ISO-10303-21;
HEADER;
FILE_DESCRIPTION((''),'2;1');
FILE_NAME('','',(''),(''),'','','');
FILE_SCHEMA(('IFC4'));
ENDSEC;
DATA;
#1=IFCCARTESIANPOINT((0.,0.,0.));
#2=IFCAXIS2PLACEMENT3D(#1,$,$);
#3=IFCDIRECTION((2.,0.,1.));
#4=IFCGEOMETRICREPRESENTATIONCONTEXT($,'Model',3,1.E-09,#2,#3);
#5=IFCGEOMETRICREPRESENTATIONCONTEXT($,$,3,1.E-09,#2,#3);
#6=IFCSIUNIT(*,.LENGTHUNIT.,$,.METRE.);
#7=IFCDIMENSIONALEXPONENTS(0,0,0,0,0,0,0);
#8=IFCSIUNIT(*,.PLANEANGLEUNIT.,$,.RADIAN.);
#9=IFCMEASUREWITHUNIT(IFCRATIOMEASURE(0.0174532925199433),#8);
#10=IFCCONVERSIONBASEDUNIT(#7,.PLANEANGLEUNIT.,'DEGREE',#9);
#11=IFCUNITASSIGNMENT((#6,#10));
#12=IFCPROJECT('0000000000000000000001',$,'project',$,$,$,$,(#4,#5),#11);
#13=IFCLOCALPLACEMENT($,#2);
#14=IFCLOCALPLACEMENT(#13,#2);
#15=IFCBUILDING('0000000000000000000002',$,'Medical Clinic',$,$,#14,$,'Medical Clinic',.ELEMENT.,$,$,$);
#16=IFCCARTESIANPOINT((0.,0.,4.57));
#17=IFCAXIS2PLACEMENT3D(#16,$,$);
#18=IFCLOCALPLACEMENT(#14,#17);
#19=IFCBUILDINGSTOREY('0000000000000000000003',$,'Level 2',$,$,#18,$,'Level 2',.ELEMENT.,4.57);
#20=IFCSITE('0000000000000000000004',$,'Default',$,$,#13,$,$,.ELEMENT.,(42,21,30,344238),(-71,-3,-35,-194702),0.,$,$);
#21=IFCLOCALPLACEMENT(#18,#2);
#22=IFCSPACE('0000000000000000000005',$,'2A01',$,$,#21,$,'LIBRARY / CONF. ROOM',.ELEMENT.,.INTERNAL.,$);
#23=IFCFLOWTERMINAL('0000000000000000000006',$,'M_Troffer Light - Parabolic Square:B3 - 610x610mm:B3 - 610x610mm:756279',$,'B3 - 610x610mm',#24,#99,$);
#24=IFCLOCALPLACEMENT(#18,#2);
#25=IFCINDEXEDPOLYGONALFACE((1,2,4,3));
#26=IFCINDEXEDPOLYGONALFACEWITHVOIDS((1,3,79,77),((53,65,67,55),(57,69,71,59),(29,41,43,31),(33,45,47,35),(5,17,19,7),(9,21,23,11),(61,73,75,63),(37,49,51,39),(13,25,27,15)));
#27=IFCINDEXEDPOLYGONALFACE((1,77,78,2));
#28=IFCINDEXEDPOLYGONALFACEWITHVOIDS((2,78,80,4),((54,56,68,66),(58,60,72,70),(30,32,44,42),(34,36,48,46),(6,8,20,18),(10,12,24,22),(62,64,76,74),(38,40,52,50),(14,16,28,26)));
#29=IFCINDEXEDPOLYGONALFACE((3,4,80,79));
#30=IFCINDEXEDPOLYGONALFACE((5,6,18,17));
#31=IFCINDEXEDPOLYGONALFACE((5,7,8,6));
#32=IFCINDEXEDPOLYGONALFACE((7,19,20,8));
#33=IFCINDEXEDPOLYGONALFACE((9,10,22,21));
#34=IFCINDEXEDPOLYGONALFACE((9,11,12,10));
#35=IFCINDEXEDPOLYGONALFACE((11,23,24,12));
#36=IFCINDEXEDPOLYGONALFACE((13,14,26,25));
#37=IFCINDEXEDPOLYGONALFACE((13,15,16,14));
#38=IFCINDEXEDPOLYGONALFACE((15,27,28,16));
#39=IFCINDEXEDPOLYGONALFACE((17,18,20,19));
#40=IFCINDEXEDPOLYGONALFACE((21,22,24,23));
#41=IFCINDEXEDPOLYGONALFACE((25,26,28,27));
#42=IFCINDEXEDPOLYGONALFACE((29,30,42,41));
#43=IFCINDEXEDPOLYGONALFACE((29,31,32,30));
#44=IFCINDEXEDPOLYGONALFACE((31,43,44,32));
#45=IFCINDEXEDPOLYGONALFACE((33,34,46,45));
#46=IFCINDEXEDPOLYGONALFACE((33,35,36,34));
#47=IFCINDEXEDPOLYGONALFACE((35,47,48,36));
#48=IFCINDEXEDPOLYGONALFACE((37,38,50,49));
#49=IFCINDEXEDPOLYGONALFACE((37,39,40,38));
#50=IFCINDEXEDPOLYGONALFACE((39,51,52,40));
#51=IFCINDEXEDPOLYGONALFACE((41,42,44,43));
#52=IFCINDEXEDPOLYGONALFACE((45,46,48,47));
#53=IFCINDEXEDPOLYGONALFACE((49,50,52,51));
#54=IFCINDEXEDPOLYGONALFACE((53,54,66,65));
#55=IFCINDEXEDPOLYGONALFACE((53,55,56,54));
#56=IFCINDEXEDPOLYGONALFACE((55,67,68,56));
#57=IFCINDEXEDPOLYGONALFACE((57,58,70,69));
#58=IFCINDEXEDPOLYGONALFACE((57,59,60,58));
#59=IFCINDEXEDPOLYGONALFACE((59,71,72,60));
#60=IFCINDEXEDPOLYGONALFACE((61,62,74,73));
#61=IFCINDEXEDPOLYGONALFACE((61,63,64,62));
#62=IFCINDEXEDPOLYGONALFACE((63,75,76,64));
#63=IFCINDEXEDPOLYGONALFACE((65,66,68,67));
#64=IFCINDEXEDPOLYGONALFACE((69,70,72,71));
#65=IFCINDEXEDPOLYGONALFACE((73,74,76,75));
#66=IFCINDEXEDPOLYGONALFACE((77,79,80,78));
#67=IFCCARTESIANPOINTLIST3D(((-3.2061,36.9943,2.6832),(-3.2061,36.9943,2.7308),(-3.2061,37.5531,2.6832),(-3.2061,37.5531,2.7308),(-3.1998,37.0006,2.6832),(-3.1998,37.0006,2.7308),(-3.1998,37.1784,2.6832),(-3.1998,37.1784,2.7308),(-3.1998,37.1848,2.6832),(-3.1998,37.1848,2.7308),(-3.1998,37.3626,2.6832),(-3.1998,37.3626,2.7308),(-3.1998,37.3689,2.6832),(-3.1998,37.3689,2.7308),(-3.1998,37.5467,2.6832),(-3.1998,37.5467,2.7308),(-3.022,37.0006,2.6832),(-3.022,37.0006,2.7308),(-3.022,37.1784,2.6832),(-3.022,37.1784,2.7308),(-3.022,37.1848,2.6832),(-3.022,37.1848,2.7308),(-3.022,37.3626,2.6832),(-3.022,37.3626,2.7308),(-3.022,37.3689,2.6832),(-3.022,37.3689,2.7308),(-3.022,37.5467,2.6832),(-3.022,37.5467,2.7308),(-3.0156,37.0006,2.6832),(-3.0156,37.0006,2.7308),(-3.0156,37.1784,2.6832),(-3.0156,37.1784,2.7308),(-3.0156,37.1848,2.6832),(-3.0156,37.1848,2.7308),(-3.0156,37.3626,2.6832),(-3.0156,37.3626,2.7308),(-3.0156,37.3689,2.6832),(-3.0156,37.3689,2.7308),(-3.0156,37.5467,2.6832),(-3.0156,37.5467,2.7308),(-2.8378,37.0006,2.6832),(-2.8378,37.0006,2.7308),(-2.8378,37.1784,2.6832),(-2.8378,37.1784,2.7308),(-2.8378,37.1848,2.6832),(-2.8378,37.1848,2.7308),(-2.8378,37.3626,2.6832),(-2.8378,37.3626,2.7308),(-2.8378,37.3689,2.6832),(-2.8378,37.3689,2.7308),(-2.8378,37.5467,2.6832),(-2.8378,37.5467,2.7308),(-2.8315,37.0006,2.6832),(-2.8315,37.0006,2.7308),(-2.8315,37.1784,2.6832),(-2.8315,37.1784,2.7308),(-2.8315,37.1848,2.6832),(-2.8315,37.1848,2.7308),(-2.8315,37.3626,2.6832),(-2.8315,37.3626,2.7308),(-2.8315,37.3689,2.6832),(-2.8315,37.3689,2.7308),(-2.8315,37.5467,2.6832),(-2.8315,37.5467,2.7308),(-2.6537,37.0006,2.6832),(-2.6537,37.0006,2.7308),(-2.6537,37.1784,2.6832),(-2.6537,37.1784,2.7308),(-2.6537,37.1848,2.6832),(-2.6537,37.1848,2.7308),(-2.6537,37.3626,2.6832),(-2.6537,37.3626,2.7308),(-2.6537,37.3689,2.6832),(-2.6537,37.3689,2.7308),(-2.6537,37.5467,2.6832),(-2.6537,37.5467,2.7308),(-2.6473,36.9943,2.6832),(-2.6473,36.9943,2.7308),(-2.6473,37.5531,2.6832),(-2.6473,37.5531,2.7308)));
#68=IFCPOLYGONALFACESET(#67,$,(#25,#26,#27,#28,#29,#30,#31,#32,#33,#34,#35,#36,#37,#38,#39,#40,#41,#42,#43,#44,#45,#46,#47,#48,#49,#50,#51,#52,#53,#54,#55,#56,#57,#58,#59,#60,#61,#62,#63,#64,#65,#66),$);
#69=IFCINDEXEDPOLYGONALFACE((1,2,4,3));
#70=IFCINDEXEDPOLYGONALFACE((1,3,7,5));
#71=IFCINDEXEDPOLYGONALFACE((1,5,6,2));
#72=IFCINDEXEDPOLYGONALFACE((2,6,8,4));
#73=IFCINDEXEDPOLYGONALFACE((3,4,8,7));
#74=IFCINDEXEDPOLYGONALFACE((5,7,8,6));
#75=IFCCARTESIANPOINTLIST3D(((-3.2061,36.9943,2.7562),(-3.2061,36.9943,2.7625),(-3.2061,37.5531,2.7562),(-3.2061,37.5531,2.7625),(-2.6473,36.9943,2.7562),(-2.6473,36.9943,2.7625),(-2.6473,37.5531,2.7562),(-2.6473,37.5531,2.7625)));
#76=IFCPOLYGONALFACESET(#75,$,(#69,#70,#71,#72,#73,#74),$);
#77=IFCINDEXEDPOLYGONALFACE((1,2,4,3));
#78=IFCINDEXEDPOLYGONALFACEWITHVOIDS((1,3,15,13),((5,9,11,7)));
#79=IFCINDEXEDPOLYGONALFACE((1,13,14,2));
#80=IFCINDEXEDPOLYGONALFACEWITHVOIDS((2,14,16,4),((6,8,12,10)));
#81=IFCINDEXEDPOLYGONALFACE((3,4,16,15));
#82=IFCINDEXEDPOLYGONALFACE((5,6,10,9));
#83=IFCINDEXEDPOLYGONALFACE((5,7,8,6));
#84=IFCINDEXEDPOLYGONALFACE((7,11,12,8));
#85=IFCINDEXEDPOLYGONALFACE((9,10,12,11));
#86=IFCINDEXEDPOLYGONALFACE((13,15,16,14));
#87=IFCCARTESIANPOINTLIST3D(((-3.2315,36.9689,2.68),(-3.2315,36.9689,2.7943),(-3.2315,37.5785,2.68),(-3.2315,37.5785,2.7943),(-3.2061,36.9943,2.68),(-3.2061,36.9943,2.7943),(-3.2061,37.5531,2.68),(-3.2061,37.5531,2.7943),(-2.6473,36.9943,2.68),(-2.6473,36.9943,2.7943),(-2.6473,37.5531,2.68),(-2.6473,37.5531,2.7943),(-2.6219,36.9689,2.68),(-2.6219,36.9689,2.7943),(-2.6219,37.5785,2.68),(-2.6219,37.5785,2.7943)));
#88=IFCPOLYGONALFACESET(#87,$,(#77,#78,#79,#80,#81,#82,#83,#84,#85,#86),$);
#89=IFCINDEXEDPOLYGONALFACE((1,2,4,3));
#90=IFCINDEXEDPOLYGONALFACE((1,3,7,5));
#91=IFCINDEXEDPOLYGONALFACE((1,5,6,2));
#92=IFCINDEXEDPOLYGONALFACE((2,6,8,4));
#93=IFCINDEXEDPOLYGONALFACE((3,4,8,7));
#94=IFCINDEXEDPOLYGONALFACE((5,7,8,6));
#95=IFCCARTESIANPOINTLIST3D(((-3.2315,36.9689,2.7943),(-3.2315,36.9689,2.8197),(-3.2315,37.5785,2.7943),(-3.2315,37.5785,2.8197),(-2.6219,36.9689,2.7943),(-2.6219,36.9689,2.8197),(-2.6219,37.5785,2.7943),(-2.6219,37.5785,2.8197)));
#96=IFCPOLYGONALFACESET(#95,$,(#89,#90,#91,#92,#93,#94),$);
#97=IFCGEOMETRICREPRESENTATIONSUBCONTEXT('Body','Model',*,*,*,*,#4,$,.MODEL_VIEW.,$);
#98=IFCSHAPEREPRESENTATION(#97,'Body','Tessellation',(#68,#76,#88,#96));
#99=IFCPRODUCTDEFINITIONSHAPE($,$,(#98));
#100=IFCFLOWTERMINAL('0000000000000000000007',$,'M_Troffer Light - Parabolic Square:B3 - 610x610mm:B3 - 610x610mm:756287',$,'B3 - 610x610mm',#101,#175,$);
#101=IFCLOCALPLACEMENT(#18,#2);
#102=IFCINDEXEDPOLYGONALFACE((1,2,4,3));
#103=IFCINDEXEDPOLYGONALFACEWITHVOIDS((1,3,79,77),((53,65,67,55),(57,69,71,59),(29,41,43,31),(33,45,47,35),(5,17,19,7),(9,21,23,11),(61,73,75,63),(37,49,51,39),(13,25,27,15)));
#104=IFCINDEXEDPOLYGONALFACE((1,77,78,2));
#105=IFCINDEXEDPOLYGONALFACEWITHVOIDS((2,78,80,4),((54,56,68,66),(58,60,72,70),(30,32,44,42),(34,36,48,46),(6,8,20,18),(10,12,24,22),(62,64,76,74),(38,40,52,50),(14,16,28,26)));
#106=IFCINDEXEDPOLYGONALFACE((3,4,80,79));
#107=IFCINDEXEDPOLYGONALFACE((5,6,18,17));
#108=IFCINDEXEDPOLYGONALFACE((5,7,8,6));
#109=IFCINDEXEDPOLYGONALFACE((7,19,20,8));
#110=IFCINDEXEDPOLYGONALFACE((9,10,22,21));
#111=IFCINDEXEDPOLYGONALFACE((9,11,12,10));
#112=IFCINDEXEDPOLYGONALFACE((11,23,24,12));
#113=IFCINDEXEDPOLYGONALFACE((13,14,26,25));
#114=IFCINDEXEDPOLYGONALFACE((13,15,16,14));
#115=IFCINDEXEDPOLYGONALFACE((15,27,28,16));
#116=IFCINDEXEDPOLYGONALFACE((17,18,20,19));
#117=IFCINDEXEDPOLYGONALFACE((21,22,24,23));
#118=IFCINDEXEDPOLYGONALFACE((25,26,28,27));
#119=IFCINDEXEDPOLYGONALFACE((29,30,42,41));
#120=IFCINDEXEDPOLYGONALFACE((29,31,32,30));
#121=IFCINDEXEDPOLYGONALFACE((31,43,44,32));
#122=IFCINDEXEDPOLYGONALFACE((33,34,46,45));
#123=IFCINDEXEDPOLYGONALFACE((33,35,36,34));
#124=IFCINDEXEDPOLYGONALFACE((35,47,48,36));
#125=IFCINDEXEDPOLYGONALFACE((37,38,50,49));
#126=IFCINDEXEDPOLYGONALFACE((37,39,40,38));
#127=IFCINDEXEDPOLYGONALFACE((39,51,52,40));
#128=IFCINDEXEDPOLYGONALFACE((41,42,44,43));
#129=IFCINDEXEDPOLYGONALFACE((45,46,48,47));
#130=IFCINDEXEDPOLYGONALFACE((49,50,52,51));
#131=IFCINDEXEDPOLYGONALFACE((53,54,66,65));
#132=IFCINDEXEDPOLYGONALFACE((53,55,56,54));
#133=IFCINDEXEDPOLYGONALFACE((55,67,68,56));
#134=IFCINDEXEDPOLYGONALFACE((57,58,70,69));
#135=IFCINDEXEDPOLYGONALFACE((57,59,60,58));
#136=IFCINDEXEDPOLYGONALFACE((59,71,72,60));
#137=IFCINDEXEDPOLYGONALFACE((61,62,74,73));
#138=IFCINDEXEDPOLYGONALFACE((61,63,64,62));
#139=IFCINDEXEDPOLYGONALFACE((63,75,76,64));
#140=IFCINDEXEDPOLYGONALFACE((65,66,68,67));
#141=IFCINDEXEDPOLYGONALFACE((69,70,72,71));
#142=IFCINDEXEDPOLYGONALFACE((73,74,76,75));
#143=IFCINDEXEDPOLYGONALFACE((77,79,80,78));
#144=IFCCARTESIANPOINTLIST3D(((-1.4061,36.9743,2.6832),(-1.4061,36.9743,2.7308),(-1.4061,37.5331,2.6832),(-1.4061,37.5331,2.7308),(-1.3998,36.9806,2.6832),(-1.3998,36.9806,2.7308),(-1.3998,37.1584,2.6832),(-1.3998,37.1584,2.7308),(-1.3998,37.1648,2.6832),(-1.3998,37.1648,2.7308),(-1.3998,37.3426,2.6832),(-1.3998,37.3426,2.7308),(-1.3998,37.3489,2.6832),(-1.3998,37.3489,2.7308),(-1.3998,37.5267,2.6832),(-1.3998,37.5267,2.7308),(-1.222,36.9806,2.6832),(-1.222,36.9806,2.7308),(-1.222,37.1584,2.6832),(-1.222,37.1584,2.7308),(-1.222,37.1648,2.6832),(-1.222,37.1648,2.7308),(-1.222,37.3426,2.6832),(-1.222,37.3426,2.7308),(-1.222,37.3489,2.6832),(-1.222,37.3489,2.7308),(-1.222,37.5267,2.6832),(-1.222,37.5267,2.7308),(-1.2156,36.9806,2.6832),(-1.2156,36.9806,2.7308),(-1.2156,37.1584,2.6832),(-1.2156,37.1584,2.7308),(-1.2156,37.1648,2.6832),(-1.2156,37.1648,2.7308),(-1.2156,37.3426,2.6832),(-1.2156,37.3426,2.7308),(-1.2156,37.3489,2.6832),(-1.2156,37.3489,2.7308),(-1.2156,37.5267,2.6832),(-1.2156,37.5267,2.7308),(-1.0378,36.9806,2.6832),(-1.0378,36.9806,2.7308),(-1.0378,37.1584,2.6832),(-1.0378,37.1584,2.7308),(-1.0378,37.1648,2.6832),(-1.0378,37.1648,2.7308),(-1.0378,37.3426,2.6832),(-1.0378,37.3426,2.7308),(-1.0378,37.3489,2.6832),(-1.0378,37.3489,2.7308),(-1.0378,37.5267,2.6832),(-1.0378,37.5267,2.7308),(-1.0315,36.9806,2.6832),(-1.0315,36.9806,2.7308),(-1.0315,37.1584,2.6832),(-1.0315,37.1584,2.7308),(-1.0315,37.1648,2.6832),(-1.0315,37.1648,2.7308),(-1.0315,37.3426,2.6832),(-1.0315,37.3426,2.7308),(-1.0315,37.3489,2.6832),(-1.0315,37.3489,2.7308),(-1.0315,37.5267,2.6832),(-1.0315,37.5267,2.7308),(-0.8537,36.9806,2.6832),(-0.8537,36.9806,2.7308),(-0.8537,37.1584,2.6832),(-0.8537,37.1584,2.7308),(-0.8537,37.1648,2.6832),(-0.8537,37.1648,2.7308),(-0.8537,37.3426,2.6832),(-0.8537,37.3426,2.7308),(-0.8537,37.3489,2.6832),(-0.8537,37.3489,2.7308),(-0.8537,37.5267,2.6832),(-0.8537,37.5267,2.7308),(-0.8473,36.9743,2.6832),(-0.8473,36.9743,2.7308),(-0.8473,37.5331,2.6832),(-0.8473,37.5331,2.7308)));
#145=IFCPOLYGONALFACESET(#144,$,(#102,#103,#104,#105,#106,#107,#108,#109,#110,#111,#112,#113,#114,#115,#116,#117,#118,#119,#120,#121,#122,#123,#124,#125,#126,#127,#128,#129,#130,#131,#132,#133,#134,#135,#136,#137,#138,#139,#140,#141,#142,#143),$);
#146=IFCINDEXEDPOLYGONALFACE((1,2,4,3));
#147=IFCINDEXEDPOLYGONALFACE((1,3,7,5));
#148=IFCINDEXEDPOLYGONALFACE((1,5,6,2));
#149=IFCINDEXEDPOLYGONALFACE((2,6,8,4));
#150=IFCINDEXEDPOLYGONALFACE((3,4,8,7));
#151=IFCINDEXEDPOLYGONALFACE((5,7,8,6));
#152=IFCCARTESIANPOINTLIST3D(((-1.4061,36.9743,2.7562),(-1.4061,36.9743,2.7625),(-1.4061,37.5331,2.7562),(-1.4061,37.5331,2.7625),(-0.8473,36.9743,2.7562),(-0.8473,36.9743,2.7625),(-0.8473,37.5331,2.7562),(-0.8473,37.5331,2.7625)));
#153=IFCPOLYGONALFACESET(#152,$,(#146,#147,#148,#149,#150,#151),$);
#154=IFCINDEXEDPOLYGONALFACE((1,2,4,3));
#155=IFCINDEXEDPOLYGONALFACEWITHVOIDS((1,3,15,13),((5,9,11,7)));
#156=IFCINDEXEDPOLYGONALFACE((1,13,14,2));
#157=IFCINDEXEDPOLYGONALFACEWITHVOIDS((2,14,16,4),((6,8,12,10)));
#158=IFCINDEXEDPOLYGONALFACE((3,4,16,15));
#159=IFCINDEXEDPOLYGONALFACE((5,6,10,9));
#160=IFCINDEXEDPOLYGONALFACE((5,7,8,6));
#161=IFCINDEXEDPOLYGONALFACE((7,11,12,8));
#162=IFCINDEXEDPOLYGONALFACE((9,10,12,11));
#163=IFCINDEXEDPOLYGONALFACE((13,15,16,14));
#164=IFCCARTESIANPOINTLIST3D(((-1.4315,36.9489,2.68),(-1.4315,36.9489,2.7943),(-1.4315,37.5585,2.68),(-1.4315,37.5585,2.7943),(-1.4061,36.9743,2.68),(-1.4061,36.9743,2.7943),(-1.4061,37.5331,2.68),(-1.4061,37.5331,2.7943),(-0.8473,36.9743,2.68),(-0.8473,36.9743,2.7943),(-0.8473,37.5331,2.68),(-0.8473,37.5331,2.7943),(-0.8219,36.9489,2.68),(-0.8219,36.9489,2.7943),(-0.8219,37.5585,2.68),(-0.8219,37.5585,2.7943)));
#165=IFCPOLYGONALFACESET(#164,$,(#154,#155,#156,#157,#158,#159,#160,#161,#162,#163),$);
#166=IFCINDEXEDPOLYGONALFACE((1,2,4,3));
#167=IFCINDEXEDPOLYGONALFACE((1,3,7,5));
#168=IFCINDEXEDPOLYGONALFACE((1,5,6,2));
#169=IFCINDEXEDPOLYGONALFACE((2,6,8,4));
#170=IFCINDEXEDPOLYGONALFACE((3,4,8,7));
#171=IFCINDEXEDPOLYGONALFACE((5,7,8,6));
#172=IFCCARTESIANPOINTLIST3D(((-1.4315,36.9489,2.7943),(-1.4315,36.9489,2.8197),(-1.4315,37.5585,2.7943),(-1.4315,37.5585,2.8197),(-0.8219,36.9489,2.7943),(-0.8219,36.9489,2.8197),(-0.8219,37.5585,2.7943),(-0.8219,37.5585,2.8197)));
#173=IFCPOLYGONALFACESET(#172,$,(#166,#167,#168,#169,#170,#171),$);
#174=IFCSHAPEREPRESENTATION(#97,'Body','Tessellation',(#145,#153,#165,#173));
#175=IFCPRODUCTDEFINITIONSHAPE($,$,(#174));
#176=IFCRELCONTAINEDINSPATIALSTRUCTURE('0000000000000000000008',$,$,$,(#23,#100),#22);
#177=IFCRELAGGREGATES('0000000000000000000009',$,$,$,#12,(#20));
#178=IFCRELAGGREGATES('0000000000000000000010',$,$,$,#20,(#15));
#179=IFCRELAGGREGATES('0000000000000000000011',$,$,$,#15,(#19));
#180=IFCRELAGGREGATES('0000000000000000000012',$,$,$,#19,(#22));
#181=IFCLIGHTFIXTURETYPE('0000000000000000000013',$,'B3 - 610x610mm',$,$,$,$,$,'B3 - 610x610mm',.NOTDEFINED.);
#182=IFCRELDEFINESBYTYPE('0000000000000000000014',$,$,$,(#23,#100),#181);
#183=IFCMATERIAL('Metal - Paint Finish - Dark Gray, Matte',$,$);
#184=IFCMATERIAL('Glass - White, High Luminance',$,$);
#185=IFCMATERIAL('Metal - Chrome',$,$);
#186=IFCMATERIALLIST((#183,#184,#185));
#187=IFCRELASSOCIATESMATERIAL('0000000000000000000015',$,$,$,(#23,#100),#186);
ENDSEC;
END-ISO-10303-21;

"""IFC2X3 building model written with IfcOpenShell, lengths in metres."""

from ifc_helpers import new_model, entity, si_unit, converted_unit, direction, frame, origin, origin_2d_with_axis, place, context, subcontext, project, spatial, polyline, rectangle, outline, extrude, source, transform, mapped, material, material_list, type_object, type_shapes, element, save


model = new_model("IFC2X3")

# Units and contexts
model_context = context("Model", 3, precision=1e-09, world=origin(), true_north=direction((2.0, 0.0, 1.0)))
context_of_model = context(None, 3, precision=1e-09, world=origin(), true_north=direction((2.0, 0.0, 1.0)))
body_context = subcontext(model_context, "Body", "Model", "MODEL_VIEW")
ifc_project = project(units=[si_unit("LENGTHUNIT", "METRE"), converted_unit("PLANEANGLEUNIT", "DEGREE", entity("IfcRatioMeasure", 0.0174532925199433), si_unit("PLANEANGLEUNIT", "RADIAN"), dimensions=[0, 0, 0, 0, 0, 0, 0])], contexts=[model_context, context_of_model])

# Site, building, storey
site_placement = place(None, origin())
site = spatial("IfcSite", under=ifc_project, at=site_placement, Name="Default", CompositionType="ELEMENT", RefLatitude=(42, 21, 30, 344238), RefLongitude=(-71, -3, -35, -194702), RefElevation=0.0)
building_placement = place(site_placement, origin())
building = spatial("IfcBuilding", under=site, at=building_placement, Name="Medical Clinic", LongName="Medical Clinic", CompositionType="ELEMENT")
storey_placement = place(building_placement, frame((0.0, 0.0, 4.57)))
storey = spatial("IfcBuildingStorey", under=building, at=storey_placement, Name="Level 2", LongName="Level 2", CompositionType="ELEMENT", Elevation=4.57)

# Shared definitions
space_1_placement = place(storey_placement, origin())
space_1 = spatial("IfcSpace", under=storey, at=space_1_placement, Name="2A01", LongName="LIBRARY / CONF. ROOM", CompositionType="ELEMENT", InteriorOrExteriorSpace="INTERNAL")

# Flow terminals
ifc_material_1 = material(Name="Metal - Paint Finish - Dark Gray, Matte")
ifc_material_2 = material(Name="Glass - White, High Luminance")
ifc_material_3 = material(Name="Metal - Chrome")
ifc_material_list = material_list([ifc_material_1, ifc_material_2, ifc_material_3])
light_fixture_type_1 = type_object("IfcLightFixtureType", Name="B3 - 610x610mm", ElementType="B3 - 610x610mm", PredefinedType="NOTDEFINED")
shared_shape_1 = source(origin(), body_context, "Body", "SweptSolid", [
    extrude(outline(polyline([(-0.2794, -0.2794), (0.2794, -0.2794), (0.2794, 0.2794), (-0.2794, 0.2794), (-0.2794, -0.2794)]), holes=[polyline([(-0.0952, 0.0953), (-0.273, 0.0953), (-0.273, 0.2731), (-0.0952, 0.2731), (-0.0952, 0.0953)]), polyline([(0.2731, 0.0953), (0.0953, 0.0953), (0.0953, 0.2731), (0.2731, 0.2731), (0.2731, 0.0953)]), polyline([(-0.0889, 0.2731), (0.0889, 0.2731), (0.0889, 0.0953), (-0.0889, 0.0953), (-0.0889, 0.2731)]), polyline([(0.2731, -0.273), (0.0953, -0.273), (0.0953, -0.0952), (0.2731, -0.0952), (0.2731, -0.273)]), polyline([(0.0889, -0.273), (-0.0889, -0.273), (-0.0889, -0.0952), (0.0889, -0.0952), (0.0889, -0.273)]), polyline([(-0.0952, -0.273), (-0.273, -0.273), (-0.273, -0.0952), (-0.0952, -0.0952), (-0.0952, -0.273)]), polyline([(-0.0952, -0.0889), (-0.273, -0.0889), (-0.273, 0.0889), (-0.0952, 0.0889), (-0.0952, -0.0889)]), polyline([(0.0889, -0.0889), (-0.0889, -0.0889), (-0.0889, 0.0889), (0.0889, 0.0889), (0.0889, -0.0889)]), polyline([(0.2731, -0.0889), (0.0953, -0.0889), (0.0953, 0.0889), (0.2731, 0.0889), (0.2731, -0.0889)])]), frame((0.0, -0.3048, -0.0508), z_axis=(0.0, 0.0, 1.0), x_axis=(-1.0, 0.0, 0.0)), (0.0, 0.0, 1.0), 0.0476),
    extrude(rectangle(XDim=0.5588, YDim=0.5588, at=origin_2d_with_axis()), frame((0.0, -0.3048, -0.0825), z_axis=(0.0, 0.0, 1.0), x_axis=(-1.0, 0.0, 0.0)), (0.0, 0.0, 1.0), 0.0064),
    extrude(outline(polyline([(-0.3048, -0.3048), (0.3048, -0.3048), (0.3048, 0.3048), (-0.3048, 0.3048), (-0.3048, -0.3048)]), holes=[polyline([(0.2794, 0.2794), (0.2794, -0.2794), (-0.2794, -0.2794), (-0.2794, 0.2794), (0.2794, 0.2794)])]), frame((0.0, -0.3048, -0.1143)), (0.0, 0.0, 1.0), 0.1143),
    extrude(rectangle(XDim=0.6096, YDim=0.6096, at=origin_2d_with_axis()), frame((0.0, -0.3048, -0.1397), z_axis=(0.0, 0.0, 1.0), x_axis=(-1.0, 0.0, 0.0)), (0.0, 0.0, 1.0), 0.0254),
])
type_shapes(light_fixture_type_1, [shared_shape_1])
for number, where, z_axis, x_axis, name in (
    (1, (-2.9267, 36.9689, 2.68), (0.0, 0.0, -1.0), (1.0, 0.0, 0.0), "M_Troffer Light - Parabolic Square:B3 - 610x610mm:B3 - 610x610mm:756279"),
    (2, (-1.1267, 36.9489, 2.68), (0.0, 0.0, -1.0), (1.0, 0.0, 0.0), "M_Troffer Light - Parabolic Square:B3 - 610x610mm:B3 - 610x610mm:756287"),
):
    element("IfcFlowTerminal", number, at=place(space_1_placement, frame(where, z_axis=z_axis, x_axis=x_axis)), inside=space_1, type_object=light_fixture_type_1, material=ifc_material_list, Name=name, ObjectType="B3 - 610x610mm", context=body_context, shape_type="MappedRepresentation", body=[
        mapped(shared_shape_1, transform((0.0, 0.0, 0.0), scale=1.0)),
    ])

save(model, "model.ifc")
